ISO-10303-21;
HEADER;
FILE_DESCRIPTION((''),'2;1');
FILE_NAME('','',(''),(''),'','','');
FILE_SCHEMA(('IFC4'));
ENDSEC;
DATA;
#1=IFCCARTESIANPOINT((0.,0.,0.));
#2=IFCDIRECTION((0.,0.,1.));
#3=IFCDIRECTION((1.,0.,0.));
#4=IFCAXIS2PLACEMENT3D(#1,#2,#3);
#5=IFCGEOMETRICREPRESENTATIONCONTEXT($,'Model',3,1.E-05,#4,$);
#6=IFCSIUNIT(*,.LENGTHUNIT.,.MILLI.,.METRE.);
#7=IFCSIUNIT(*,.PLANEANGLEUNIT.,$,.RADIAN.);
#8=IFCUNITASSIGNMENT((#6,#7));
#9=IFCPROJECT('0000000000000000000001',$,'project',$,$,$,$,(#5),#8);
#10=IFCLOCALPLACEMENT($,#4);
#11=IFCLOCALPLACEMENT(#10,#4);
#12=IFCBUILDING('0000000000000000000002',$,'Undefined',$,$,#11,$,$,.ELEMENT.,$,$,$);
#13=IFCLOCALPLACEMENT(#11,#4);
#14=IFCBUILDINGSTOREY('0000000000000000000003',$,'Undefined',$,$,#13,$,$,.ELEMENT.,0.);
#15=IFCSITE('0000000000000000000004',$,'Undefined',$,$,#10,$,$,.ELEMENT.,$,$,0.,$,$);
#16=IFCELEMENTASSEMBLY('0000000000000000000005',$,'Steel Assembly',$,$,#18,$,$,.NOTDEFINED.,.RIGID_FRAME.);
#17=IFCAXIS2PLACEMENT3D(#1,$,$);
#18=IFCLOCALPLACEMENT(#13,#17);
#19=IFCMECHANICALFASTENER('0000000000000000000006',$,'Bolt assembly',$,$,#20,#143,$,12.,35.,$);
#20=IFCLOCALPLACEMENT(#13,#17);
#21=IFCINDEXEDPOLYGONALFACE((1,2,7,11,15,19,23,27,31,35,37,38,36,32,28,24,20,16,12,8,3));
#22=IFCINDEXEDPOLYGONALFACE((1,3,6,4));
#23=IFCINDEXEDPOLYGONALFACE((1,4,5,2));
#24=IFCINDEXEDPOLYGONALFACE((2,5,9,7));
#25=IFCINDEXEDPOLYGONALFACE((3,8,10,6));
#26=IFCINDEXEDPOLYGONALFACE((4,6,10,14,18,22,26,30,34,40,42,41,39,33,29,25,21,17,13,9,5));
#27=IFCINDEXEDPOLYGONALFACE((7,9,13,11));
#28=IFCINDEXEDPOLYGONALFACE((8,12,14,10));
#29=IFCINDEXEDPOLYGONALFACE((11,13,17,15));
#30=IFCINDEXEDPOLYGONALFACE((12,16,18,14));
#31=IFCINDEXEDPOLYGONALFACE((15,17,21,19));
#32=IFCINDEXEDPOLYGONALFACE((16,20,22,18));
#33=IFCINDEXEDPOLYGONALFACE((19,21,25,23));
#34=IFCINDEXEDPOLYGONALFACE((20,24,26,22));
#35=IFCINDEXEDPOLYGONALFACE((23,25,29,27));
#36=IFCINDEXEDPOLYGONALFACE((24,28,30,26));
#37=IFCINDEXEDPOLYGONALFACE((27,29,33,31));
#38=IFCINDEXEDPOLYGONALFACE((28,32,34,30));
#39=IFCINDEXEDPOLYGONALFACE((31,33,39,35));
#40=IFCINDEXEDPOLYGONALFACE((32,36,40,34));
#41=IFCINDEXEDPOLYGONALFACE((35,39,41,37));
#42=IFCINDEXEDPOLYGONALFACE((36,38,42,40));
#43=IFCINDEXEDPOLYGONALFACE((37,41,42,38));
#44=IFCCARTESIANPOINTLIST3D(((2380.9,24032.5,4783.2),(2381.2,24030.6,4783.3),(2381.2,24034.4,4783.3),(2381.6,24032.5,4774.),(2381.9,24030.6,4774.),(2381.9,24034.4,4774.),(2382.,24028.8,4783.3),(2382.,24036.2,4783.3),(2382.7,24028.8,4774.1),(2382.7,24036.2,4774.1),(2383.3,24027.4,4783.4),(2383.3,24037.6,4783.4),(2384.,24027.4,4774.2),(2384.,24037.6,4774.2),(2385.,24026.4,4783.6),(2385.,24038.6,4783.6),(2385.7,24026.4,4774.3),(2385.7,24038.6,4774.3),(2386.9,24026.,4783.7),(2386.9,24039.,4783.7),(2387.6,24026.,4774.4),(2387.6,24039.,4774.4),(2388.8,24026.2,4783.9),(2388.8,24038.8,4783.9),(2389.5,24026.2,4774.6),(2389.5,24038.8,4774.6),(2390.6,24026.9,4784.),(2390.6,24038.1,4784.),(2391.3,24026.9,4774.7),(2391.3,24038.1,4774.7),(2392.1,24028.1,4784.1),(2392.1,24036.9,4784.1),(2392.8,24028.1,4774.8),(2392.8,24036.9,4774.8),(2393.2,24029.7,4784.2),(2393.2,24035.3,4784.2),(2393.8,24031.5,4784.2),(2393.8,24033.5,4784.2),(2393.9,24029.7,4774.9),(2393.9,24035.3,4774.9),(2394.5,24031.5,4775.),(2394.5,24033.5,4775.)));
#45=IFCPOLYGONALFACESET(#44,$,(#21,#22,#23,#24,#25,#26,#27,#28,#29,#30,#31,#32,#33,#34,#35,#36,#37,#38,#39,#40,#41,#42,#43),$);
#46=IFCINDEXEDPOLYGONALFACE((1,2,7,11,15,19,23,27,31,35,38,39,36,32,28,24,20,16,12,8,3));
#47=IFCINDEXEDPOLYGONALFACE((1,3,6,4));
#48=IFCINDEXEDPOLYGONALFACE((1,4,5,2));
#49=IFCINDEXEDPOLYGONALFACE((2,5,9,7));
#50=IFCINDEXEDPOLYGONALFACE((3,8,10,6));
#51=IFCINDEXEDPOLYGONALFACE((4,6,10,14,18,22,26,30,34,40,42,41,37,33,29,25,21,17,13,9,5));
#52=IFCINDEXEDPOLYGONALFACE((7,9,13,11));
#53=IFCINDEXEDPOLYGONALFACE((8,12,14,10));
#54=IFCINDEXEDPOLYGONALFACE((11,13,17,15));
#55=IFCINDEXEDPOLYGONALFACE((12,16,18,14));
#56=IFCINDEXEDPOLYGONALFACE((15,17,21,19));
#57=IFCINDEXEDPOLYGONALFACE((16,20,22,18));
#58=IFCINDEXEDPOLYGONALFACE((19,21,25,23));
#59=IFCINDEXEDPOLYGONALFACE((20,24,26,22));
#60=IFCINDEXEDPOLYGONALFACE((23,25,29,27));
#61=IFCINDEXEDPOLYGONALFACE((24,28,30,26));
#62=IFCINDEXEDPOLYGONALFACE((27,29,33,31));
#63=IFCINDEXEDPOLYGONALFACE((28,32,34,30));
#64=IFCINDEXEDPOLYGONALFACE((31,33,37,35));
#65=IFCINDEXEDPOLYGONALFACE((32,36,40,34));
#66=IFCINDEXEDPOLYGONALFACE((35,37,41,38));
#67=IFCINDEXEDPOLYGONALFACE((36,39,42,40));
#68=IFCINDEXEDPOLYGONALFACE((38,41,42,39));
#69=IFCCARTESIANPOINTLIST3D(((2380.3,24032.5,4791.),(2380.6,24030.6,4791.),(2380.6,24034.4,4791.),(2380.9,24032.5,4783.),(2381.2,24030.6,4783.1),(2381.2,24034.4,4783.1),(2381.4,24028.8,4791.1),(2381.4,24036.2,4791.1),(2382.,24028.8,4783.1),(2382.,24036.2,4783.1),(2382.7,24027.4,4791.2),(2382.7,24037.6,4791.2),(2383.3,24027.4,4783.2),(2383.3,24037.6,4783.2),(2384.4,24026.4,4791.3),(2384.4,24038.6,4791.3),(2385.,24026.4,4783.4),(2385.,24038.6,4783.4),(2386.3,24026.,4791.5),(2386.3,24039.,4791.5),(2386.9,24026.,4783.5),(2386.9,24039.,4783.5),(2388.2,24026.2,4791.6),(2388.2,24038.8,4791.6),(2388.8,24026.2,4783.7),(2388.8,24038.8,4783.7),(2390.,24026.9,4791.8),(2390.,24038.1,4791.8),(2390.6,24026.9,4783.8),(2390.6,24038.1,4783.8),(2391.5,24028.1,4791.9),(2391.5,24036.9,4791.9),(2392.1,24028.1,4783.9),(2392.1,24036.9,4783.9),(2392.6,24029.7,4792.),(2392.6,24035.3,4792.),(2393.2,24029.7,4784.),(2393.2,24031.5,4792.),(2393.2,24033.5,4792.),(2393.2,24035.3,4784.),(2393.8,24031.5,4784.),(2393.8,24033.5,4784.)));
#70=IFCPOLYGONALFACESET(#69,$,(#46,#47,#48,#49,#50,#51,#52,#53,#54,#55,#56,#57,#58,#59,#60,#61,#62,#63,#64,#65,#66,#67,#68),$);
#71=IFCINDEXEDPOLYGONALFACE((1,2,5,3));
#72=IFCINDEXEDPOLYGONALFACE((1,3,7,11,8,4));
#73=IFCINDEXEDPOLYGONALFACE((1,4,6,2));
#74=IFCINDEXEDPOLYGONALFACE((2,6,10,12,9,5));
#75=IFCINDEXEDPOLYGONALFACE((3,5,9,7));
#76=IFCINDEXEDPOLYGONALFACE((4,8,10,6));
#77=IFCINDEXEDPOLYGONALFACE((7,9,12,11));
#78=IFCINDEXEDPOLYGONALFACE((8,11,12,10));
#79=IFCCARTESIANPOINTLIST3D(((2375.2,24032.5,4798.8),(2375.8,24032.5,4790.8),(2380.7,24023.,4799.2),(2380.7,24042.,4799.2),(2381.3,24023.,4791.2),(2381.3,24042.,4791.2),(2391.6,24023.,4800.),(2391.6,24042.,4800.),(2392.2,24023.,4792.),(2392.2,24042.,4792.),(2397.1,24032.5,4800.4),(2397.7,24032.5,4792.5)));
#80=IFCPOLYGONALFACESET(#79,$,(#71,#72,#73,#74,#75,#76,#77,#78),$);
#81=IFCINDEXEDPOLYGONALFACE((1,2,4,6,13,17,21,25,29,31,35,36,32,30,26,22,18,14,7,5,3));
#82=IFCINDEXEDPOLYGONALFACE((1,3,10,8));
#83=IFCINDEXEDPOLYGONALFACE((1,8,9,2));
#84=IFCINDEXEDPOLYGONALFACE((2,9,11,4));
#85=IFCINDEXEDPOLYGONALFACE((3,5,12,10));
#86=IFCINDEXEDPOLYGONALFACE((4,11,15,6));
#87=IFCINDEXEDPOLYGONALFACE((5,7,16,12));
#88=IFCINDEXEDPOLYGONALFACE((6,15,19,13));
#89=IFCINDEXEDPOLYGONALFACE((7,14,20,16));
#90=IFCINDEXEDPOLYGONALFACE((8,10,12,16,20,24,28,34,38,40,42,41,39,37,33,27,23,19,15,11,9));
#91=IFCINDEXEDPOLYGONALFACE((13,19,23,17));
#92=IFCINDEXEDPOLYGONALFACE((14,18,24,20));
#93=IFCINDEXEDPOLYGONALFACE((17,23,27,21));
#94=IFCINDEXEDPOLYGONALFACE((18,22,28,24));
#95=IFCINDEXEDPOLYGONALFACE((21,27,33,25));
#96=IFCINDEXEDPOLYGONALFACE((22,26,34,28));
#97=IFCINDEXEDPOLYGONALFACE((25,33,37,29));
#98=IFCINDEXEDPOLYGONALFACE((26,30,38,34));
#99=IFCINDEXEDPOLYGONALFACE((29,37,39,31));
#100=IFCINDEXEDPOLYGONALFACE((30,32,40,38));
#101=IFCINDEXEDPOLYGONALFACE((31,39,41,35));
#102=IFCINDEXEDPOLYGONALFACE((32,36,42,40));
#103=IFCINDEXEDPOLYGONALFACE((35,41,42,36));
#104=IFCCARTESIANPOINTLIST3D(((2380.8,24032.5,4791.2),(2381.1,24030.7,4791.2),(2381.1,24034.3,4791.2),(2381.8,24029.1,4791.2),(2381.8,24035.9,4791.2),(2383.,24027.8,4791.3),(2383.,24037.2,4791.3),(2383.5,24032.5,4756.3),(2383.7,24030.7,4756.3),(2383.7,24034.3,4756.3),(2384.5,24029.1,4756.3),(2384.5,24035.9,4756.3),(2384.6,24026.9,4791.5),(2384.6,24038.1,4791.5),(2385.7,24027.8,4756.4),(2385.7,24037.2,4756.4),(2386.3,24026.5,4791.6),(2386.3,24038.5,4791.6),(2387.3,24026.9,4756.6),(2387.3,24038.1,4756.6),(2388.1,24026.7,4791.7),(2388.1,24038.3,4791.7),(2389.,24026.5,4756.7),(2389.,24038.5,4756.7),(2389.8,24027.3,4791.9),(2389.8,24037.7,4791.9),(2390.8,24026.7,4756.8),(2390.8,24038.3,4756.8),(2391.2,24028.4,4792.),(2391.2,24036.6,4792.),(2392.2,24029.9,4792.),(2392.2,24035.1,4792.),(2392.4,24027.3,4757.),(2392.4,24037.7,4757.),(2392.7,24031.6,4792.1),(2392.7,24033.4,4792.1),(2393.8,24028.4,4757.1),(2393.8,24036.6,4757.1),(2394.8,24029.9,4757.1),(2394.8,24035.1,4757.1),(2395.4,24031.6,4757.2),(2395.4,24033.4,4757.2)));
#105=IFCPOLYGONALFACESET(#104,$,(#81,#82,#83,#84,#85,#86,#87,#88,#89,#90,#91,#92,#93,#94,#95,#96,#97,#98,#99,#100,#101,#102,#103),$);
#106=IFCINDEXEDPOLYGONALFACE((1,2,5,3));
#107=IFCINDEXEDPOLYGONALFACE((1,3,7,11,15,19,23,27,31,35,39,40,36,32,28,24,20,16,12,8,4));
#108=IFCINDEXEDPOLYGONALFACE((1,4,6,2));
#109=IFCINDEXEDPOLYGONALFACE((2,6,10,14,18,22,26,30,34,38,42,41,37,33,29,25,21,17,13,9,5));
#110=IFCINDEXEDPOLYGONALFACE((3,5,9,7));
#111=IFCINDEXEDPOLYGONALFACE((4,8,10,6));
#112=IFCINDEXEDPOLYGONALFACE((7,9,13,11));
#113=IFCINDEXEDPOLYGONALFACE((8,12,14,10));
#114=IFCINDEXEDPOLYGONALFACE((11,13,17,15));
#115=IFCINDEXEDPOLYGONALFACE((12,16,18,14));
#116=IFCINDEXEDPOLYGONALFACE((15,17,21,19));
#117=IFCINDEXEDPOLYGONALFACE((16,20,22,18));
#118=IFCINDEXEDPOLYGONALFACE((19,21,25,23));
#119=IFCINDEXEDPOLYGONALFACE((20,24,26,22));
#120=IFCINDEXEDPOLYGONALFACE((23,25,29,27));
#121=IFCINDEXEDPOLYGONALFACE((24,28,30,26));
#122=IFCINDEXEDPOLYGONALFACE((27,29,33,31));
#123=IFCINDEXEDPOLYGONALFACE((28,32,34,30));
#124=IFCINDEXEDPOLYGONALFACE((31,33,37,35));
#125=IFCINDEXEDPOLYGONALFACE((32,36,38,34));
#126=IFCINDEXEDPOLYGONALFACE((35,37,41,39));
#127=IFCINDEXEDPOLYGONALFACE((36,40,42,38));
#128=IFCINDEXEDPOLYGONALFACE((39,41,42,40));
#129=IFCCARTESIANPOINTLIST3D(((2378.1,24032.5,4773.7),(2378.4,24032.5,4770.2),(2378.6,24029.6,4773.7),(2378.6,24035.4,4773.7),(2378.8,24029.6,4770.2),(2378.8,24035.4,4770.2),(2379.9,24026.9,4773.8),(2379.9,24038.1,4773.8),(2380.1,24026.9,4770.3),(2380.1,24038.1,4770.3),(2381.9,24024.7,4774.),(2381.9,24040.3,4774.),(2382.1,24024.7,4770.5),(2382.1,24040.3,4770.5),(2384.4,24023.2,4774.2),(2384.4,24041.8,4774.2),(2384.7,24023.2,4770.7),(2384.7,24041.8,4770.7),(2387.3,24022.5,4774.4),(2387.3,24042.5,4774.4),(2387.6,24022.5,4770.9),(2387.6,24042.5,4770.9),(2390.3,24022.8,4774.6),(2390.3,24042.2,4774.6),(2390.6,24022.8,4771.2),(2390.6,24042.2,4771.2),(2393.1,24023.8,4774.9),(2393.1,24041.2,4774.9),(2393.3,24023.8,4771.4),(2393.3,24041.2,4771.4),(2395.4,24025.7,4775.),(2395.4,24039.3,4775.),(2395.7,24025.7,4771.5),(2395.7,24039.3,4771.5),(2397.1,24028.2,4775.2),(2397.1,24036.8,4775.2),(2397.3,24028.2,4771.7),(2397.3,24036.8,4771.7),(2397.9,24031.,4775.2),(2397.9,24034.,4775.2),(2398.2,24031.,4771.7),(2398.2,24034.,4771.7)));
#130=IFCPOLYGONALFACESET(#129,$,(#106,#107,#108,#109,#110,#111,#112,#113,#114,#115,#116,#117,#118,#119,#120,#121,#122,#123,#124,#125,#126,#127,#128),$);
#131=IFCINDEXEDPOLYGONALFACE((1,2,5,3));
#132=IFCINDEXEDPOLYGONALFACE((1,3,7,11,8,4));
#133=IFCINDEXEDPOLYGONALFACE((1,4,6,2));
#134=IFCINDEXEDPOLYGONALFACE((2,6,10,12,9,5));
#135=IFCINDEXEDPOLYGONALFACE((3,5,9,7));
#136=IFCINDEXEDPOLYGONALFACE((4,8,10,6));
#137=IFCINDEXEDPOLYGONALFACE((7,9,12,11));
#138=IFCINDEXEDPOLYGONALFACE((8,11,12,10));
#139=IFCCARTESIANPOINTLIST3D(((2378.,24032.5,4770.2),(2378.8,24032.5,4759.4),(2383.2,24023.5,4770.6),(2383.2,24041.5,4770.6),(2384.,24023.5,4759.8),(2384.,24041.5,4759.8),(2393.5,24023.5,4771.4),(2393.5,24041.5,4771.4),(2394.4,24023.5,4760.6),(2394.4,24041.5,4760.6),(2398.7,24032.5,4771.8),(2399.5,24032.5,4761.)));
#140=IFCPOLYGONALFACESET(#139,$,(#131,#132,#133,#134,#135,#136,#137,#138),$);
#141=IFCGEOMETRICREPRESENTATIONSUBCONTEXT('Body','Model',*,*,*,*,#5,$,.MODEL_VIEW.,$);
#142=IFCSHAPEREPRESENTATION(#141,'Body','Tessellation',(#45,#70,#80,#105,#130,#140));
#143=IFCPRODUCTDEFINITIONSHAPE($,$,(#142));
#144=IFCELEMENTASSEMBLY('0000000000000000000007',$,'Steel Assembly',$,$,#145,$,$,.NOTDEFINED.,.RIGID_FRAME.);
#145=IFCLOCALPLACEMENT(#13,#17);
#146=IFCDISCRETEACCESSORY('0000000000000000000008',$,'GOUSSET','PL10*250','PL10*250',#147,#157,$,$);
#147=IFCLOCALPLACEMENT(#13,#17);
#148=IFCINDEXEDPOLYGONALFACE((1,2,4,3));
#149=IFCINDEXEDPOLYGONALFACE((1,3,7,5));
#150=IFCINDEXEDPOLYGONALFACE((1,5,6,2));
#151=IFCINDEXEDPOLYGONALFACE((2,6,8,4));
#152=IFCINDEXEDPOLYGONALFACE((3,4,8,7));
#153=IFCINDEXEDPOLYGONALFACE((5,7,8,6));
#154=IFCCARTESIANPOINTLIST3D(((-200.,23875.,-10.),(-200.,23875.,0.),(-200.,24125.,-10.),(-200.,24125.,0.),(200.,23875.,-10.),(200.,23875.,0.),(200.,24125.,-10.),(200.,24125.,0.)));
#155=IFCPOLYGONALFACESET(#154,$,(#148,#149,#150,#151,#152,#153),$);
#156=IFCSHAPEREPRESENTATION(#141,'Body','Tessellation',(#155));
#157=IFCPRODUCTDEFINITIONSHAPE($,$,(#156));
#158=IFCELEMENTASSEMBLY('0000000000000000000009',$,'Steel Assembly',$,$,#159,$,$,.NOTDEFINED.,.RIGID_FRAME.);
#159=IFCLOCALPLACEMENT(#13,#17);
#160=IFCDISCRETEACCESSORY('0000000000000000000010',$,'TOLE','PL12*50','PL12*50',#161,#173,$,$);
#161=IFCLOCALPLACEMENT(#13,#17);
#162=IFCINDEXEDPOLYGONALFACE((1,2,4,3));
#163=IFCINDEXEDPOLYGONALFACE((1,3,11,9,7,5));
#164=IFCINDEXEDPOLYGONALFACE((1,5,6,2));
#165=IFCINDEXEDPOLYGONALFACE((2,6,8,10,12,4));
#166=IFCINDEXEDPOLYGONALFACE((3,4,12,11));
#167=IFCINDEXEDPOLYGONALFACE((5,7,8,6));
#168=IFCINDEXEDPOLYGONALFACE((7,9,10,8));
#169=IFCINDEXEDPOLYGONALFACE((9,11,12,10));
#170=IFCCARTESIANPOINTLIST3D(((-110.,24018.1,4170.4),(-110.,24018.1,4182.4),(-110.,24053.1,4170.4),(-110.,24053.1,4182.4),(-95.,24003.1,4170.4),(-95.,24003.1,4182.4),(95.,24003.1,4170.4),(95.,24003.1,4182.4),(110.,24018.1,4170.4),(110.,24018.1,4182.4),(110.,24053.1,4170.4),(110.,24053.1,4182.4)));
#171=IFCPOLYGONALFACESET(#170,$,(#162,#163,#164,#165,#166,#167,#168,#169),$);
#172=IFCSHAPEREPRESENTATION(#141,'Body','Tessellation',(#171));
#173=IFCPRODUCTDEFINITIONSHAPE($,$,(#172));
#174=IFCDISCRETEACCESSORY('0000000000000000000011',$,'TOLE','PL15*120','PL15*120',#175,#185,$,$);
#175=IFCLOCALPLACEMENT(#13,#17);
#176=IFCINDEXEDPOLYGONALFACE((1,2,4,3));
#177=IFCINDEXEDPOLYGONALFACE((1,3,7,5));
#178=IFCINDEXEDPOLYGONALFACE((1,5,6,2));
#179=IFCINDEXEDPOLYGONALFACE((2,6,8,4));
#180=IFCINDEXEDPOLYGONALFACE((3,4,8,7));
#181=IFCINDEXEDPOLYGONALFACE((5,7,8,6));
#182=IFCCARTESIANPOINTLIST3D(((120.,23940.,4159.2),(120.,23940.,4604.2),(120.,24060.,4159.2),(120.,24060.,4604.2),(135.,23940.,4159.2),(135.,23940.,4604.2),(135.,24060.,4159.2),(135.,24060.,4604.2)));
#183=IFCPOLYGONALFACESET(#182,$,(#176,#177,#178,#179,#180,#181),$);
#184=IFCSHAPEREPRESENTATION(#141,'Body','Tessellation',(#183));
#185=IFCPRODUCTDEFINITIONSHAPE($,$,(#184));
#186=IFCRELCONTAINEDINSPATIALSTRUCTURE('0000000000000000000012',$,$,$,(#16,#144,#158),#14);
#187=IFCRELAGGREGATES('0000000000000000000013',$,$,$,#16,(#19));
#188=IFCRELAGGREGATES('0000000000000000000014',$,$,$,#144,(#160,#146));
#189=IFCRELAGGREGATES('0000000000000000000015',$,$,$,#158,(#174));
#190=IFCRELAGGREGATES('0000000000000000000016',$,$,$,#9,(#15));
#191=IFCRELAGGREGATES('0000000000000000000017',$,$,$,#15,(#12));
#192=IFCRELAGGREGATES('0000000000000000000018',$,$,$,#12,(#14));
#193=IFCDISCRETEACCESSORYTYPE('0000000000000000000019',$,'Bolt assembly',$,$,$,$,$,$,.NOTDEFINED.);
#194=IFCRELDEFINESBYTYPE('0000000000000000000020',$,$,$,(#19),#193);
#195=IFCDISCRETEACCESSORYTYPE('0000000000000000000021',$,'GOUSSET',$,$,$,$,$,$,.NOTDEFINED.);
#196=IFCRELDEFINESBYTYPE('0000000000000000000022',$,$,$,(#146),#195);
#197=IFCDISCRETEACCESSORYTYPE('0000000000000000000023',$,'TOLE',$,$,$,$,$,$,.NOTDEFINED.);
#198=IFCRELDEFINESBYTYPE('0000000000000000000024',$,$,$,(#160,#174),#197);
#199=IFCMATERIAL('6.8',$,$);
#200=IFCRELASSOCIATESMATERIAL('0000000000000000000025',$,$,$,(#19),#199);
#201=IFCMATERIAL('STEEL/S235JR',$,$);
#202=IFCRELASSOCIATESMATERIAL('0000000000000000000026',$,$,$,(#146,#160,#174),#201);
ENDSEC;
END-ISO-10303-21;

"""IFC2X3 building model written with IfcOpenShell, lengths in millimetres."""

from ifc_helpers import new_model, si_unit, frame, origin_with_axes, origin_2d_with_axis, place, context, subcontext, project, spatial, polyline, rectangle, circle, outline, extrude, clip, halfspace, source, transform, mapped, material, type_object, element, aggregate, save


model = new_model("IFC2X3")

# Units and contexts
model_context = context("Model", 3, precision=1e-05, world=origin_with_axes())
body_context = subcontext(model_context, "Body", "Model", "MODEL_VIEW")
ifc_project = project(units=[si_unit("LENGTHUNIT", "METRE", prefix="MILLI"), si_unit("PLANEANGLEUNIT", "RADIAN")], contexts=[model_context])

# Site, building, storey
site_placement = place(None, origin_with_axes())
site = spatial("IfcSite", under=ifc_project, at=site_placement, Name="Undefined", CompositionType="ELEMENT", RefElevation=0.0)
building_placement = place(site_placement, origin_with_axes())
building = spatial("IfcBuilding", under=site, at=building_placement, Name="Undefined", CompositionType="ELEMENT")
storey_placement = place(building_placement, origin_with_axes())
storey = spatial("IfcBuildingStorey", under=building, at=storey_placement, Name="Undefined", CompositionType="ELEMENT", Elevation=0.0)

# Shared definitions
ifc_material_1 = material(Name="STEEL/S235JR")

# Shared definitions
ifc_material_2 = material(Name="6.8")
discrete_accessory_type_1 = type_object("IfcDiscreteAccessoryType", Name="Bolt assembly")

# Element assembly, mechanical fastener
shared_shape_1 = source(origin_with_axes(), body_context, "Body", "SweptSolid", [
    extrude(circle(Radius=6.5, at=origin_2d_with_axis()), frame((0.0, -0.1, 0.0), z_axis=(0.0, 1.0, 0.0), x_axis=(1.0, 0.0, 0.0)), (0.0, 0.0, 1.0), 9.3),
    extrude(circle(Radius=6.5, at=origin_2d_with_axis()), frame((0.0, -7.9, 0.0), z_axis=(0.0, 1.0, 0.0), x_axis=(1.0, 0.0, 0.0)), (0.0, 0.0, 1.0), 8.0),
    extrude(outline(polyline([(11.0, 0.0), (5.5, 9.5), (-5.5, 9.5), (-11.0, 0.0), (-5.5, -9.5), (5.5, -9.5), (11.0, 0.0)])), frame((0.0, -16.0, 0.0), z_axis=(0.0, 1.0, 0.0), x_axis=(1.0, 0.0, 0.0)), (0.0, 0.0, 1.0), 8.0),
    extrude(circle(Radius=6.0, at=origin_2d_with_axis()), frame((0.0, -8.0, 0.0), z_axis=(0.0, 1.0, 0.0), x_axis=(1.0, 0.0, 0.0)), (0.0, 0.0, 1.0), 35.0),
    extrude(circle(Radius=10.0, at=origin_2d_with_axis()), frame((0.0, 9.2, 0.0), z_axis=(0.0, 1.0, 0.0), x_axis=(1.0, 0.0, 0.0)), (0.0, 0.0, 1.0), 3.5),
    extrude(outline(polyline([(10.4, 0.0), (5.2, 9.0), (-5.2, 9.0), (-10.4, 0.0), (-5.2, -9.0), (5.2, -9.0), (10.4, 0.0)])), frame((0.0, 12.7, 0.0), z_axis=(0.0, 1.0, 0.0), x_axis=(1.0, 0.0, 0.0)), (0.0, 0.0, 1.0), 10.8),
])
assembly_1_placement = place(storey_placement, origin_with_axes())
assembly_1 = element("IfcElementAssembly", 1, at=assembly_1_placement, inside=storey, Name="Steel Assembly", AssemblyPlace="NOTDEFINED", PredefinedType="RIGID_FRAME")
mechanical_fastener_1_placement = place(assembly_1_placement, frame((2387.4, 24032.5, 4783.6), z_axis=(0.0, -1.0, 0.0), x_axis=(-0.997054, 0.0, -0.076696)))
mechanical_fastener_1 = element("IfcMechanicalFastener", 2, at=mechanical_fastener_1_placement, type_object=discrete_accessory_type_1, material=ifc_material_2, Name="Bolt assembly", NominalDiameter=12.0, NominalLength=35.0, context=body_context, shape_type="MappedRepresentation", body=[
    mapped(shared_shape_1, transform((0.0, 0.0, 0.0))),
])
aggregate(assembly_1, [mechanical_fastener_1])

# Element assembly, discrete accessory
assembly_2_placement = place(storey_placement, origin_with_axes())
assembly_2 = element("IfcElementAssembly", 3, at=assembly_2_placement, inside=storey, Name="Steel Assembly", AssemblyPlace="NOTDEFINED", PredefinedType="RIGID_FRAME")
discrete_accessory_type_2 = type_object("IfcDiscreteAccessoryType", Name="GOUSSET")
discrete_accessory_1_placement = place(assembly_2_placement, frame((-200.0, 24125.0, -5.0), z_axis=(0.0, 0.0, 1.0), x_axis=(0.0, -1.0, 0.0)))
discrete_accessory_1 = element("IfcDiscreteAccessory", 4, at=discrete_accessory_1_placement, type_object=discrete_accessory_type_2, material=ifc_material_1, Name="GOUSSET", Description="PL10*250", ObjectType="PL10*250", context=body_context, shape_type="SweptSolid", body=[
    extrude(outline(polyline([(0.0, 0.0), (250.0, 0.0), (250.0, 400.0), (0.0, 400.0), (0.0, 0.0)])), frame((0.0, 0.0, -5.0), z_axis=(0.0, 0.0, 1.0), x_axis=(1.0, 0.0, 0.0)), (0.0, 0.0, 1.0), 10.0),
])

# Element assembly
assembly_3_placement = place(storey_placement, origin_with_axes())
assembly_3 = element("IfcElementAssembly", 5, at=assembly_3_placement, inside=storey, Name="Steel Assembly", AssemblyPlace="NOTDEFINED", PredefinedType="RIGID_FRAME")

# Discrete accessories
discrete_accessory_type_3 = type_object("IfcDiscreteAccessoryType", Name="TOLE")
discrete_accessory_2_placement = place(assembly_2_placement, frame((-110.0, 24028.1, 4176.4), z_axis=(0.0, -1.0, 0.0), x_axis=(1.0, 0.0, 0.0)))
discrete_accessory_2 = element("IfcDiscreteAccessory", 6, at=discrete_accessory_2_placement, type_object=discrete_accessory_type_3, material=ifc_material_1, Name="TOLE", Description="PL12*50", ObjectType="PL12*50", context=body_context, shape_type="Clipping", body=[
    clip(clip(extrude(rectangle(XDim=12.0, YDim=50.0, at=origin_2d_with_axis()), frame((220.0, 0.0, 0.0), z_axis=(-1.0, 0.0, 0.0), x_axis=(0.0, -1.0, 0.0)), (0.0, 0.0, 1.0), 220.0), halfspace(frame((-35.0, 6.0, -25.0), z_axis=(-0.707107, 0.0, 0.707107), x_axis=(0.707107, 0.0, 0.707107)), False)), halfspace(frame((255.0, -6.0, -25.0), z_axis=(0.707107, 0.0, 0.707107), x_axis=(-0.707107, 0.0, 0.707107)), False)),
])
aggregate(assembly_2, [discrete_accessory_2, discrete_accessory_1])
discrete_accessory_3_placement = place(assembly_3_placement, frame((127.5, 24000.0, 4159.2), z_axis=(1.0, 0.0, 0.0), x_axis=(0.0, 0.0, 1.0)))
discrete_accessory_3 = element("IfcDiscreteAccessory", 7, at=discrete_accessory_3_placement, type_object=discrete_accessory_type_3, material=ifc_material_1, Name="TOLE", Description="PL15*120", ObjectType="PL15*120", context=body_context, shape_type="SweptSolid", body=[
    extrude(outline(polyline([(0.0, 60.0), (445.0, 60.0), (445.0, -60.0), (0.0, -60.0), (0.0, 60.0)])), frame((0.0, 0.0, -7.5), z_axis=(0.0, 0.0, 1.0), x_axis=(1.0, 0.0, 0.0)), (0.0, 0.0, 1.0), 15.0),
])
aggregate(assembly_3, [discrete_accessory_3])

save(model, "model.ifc")
